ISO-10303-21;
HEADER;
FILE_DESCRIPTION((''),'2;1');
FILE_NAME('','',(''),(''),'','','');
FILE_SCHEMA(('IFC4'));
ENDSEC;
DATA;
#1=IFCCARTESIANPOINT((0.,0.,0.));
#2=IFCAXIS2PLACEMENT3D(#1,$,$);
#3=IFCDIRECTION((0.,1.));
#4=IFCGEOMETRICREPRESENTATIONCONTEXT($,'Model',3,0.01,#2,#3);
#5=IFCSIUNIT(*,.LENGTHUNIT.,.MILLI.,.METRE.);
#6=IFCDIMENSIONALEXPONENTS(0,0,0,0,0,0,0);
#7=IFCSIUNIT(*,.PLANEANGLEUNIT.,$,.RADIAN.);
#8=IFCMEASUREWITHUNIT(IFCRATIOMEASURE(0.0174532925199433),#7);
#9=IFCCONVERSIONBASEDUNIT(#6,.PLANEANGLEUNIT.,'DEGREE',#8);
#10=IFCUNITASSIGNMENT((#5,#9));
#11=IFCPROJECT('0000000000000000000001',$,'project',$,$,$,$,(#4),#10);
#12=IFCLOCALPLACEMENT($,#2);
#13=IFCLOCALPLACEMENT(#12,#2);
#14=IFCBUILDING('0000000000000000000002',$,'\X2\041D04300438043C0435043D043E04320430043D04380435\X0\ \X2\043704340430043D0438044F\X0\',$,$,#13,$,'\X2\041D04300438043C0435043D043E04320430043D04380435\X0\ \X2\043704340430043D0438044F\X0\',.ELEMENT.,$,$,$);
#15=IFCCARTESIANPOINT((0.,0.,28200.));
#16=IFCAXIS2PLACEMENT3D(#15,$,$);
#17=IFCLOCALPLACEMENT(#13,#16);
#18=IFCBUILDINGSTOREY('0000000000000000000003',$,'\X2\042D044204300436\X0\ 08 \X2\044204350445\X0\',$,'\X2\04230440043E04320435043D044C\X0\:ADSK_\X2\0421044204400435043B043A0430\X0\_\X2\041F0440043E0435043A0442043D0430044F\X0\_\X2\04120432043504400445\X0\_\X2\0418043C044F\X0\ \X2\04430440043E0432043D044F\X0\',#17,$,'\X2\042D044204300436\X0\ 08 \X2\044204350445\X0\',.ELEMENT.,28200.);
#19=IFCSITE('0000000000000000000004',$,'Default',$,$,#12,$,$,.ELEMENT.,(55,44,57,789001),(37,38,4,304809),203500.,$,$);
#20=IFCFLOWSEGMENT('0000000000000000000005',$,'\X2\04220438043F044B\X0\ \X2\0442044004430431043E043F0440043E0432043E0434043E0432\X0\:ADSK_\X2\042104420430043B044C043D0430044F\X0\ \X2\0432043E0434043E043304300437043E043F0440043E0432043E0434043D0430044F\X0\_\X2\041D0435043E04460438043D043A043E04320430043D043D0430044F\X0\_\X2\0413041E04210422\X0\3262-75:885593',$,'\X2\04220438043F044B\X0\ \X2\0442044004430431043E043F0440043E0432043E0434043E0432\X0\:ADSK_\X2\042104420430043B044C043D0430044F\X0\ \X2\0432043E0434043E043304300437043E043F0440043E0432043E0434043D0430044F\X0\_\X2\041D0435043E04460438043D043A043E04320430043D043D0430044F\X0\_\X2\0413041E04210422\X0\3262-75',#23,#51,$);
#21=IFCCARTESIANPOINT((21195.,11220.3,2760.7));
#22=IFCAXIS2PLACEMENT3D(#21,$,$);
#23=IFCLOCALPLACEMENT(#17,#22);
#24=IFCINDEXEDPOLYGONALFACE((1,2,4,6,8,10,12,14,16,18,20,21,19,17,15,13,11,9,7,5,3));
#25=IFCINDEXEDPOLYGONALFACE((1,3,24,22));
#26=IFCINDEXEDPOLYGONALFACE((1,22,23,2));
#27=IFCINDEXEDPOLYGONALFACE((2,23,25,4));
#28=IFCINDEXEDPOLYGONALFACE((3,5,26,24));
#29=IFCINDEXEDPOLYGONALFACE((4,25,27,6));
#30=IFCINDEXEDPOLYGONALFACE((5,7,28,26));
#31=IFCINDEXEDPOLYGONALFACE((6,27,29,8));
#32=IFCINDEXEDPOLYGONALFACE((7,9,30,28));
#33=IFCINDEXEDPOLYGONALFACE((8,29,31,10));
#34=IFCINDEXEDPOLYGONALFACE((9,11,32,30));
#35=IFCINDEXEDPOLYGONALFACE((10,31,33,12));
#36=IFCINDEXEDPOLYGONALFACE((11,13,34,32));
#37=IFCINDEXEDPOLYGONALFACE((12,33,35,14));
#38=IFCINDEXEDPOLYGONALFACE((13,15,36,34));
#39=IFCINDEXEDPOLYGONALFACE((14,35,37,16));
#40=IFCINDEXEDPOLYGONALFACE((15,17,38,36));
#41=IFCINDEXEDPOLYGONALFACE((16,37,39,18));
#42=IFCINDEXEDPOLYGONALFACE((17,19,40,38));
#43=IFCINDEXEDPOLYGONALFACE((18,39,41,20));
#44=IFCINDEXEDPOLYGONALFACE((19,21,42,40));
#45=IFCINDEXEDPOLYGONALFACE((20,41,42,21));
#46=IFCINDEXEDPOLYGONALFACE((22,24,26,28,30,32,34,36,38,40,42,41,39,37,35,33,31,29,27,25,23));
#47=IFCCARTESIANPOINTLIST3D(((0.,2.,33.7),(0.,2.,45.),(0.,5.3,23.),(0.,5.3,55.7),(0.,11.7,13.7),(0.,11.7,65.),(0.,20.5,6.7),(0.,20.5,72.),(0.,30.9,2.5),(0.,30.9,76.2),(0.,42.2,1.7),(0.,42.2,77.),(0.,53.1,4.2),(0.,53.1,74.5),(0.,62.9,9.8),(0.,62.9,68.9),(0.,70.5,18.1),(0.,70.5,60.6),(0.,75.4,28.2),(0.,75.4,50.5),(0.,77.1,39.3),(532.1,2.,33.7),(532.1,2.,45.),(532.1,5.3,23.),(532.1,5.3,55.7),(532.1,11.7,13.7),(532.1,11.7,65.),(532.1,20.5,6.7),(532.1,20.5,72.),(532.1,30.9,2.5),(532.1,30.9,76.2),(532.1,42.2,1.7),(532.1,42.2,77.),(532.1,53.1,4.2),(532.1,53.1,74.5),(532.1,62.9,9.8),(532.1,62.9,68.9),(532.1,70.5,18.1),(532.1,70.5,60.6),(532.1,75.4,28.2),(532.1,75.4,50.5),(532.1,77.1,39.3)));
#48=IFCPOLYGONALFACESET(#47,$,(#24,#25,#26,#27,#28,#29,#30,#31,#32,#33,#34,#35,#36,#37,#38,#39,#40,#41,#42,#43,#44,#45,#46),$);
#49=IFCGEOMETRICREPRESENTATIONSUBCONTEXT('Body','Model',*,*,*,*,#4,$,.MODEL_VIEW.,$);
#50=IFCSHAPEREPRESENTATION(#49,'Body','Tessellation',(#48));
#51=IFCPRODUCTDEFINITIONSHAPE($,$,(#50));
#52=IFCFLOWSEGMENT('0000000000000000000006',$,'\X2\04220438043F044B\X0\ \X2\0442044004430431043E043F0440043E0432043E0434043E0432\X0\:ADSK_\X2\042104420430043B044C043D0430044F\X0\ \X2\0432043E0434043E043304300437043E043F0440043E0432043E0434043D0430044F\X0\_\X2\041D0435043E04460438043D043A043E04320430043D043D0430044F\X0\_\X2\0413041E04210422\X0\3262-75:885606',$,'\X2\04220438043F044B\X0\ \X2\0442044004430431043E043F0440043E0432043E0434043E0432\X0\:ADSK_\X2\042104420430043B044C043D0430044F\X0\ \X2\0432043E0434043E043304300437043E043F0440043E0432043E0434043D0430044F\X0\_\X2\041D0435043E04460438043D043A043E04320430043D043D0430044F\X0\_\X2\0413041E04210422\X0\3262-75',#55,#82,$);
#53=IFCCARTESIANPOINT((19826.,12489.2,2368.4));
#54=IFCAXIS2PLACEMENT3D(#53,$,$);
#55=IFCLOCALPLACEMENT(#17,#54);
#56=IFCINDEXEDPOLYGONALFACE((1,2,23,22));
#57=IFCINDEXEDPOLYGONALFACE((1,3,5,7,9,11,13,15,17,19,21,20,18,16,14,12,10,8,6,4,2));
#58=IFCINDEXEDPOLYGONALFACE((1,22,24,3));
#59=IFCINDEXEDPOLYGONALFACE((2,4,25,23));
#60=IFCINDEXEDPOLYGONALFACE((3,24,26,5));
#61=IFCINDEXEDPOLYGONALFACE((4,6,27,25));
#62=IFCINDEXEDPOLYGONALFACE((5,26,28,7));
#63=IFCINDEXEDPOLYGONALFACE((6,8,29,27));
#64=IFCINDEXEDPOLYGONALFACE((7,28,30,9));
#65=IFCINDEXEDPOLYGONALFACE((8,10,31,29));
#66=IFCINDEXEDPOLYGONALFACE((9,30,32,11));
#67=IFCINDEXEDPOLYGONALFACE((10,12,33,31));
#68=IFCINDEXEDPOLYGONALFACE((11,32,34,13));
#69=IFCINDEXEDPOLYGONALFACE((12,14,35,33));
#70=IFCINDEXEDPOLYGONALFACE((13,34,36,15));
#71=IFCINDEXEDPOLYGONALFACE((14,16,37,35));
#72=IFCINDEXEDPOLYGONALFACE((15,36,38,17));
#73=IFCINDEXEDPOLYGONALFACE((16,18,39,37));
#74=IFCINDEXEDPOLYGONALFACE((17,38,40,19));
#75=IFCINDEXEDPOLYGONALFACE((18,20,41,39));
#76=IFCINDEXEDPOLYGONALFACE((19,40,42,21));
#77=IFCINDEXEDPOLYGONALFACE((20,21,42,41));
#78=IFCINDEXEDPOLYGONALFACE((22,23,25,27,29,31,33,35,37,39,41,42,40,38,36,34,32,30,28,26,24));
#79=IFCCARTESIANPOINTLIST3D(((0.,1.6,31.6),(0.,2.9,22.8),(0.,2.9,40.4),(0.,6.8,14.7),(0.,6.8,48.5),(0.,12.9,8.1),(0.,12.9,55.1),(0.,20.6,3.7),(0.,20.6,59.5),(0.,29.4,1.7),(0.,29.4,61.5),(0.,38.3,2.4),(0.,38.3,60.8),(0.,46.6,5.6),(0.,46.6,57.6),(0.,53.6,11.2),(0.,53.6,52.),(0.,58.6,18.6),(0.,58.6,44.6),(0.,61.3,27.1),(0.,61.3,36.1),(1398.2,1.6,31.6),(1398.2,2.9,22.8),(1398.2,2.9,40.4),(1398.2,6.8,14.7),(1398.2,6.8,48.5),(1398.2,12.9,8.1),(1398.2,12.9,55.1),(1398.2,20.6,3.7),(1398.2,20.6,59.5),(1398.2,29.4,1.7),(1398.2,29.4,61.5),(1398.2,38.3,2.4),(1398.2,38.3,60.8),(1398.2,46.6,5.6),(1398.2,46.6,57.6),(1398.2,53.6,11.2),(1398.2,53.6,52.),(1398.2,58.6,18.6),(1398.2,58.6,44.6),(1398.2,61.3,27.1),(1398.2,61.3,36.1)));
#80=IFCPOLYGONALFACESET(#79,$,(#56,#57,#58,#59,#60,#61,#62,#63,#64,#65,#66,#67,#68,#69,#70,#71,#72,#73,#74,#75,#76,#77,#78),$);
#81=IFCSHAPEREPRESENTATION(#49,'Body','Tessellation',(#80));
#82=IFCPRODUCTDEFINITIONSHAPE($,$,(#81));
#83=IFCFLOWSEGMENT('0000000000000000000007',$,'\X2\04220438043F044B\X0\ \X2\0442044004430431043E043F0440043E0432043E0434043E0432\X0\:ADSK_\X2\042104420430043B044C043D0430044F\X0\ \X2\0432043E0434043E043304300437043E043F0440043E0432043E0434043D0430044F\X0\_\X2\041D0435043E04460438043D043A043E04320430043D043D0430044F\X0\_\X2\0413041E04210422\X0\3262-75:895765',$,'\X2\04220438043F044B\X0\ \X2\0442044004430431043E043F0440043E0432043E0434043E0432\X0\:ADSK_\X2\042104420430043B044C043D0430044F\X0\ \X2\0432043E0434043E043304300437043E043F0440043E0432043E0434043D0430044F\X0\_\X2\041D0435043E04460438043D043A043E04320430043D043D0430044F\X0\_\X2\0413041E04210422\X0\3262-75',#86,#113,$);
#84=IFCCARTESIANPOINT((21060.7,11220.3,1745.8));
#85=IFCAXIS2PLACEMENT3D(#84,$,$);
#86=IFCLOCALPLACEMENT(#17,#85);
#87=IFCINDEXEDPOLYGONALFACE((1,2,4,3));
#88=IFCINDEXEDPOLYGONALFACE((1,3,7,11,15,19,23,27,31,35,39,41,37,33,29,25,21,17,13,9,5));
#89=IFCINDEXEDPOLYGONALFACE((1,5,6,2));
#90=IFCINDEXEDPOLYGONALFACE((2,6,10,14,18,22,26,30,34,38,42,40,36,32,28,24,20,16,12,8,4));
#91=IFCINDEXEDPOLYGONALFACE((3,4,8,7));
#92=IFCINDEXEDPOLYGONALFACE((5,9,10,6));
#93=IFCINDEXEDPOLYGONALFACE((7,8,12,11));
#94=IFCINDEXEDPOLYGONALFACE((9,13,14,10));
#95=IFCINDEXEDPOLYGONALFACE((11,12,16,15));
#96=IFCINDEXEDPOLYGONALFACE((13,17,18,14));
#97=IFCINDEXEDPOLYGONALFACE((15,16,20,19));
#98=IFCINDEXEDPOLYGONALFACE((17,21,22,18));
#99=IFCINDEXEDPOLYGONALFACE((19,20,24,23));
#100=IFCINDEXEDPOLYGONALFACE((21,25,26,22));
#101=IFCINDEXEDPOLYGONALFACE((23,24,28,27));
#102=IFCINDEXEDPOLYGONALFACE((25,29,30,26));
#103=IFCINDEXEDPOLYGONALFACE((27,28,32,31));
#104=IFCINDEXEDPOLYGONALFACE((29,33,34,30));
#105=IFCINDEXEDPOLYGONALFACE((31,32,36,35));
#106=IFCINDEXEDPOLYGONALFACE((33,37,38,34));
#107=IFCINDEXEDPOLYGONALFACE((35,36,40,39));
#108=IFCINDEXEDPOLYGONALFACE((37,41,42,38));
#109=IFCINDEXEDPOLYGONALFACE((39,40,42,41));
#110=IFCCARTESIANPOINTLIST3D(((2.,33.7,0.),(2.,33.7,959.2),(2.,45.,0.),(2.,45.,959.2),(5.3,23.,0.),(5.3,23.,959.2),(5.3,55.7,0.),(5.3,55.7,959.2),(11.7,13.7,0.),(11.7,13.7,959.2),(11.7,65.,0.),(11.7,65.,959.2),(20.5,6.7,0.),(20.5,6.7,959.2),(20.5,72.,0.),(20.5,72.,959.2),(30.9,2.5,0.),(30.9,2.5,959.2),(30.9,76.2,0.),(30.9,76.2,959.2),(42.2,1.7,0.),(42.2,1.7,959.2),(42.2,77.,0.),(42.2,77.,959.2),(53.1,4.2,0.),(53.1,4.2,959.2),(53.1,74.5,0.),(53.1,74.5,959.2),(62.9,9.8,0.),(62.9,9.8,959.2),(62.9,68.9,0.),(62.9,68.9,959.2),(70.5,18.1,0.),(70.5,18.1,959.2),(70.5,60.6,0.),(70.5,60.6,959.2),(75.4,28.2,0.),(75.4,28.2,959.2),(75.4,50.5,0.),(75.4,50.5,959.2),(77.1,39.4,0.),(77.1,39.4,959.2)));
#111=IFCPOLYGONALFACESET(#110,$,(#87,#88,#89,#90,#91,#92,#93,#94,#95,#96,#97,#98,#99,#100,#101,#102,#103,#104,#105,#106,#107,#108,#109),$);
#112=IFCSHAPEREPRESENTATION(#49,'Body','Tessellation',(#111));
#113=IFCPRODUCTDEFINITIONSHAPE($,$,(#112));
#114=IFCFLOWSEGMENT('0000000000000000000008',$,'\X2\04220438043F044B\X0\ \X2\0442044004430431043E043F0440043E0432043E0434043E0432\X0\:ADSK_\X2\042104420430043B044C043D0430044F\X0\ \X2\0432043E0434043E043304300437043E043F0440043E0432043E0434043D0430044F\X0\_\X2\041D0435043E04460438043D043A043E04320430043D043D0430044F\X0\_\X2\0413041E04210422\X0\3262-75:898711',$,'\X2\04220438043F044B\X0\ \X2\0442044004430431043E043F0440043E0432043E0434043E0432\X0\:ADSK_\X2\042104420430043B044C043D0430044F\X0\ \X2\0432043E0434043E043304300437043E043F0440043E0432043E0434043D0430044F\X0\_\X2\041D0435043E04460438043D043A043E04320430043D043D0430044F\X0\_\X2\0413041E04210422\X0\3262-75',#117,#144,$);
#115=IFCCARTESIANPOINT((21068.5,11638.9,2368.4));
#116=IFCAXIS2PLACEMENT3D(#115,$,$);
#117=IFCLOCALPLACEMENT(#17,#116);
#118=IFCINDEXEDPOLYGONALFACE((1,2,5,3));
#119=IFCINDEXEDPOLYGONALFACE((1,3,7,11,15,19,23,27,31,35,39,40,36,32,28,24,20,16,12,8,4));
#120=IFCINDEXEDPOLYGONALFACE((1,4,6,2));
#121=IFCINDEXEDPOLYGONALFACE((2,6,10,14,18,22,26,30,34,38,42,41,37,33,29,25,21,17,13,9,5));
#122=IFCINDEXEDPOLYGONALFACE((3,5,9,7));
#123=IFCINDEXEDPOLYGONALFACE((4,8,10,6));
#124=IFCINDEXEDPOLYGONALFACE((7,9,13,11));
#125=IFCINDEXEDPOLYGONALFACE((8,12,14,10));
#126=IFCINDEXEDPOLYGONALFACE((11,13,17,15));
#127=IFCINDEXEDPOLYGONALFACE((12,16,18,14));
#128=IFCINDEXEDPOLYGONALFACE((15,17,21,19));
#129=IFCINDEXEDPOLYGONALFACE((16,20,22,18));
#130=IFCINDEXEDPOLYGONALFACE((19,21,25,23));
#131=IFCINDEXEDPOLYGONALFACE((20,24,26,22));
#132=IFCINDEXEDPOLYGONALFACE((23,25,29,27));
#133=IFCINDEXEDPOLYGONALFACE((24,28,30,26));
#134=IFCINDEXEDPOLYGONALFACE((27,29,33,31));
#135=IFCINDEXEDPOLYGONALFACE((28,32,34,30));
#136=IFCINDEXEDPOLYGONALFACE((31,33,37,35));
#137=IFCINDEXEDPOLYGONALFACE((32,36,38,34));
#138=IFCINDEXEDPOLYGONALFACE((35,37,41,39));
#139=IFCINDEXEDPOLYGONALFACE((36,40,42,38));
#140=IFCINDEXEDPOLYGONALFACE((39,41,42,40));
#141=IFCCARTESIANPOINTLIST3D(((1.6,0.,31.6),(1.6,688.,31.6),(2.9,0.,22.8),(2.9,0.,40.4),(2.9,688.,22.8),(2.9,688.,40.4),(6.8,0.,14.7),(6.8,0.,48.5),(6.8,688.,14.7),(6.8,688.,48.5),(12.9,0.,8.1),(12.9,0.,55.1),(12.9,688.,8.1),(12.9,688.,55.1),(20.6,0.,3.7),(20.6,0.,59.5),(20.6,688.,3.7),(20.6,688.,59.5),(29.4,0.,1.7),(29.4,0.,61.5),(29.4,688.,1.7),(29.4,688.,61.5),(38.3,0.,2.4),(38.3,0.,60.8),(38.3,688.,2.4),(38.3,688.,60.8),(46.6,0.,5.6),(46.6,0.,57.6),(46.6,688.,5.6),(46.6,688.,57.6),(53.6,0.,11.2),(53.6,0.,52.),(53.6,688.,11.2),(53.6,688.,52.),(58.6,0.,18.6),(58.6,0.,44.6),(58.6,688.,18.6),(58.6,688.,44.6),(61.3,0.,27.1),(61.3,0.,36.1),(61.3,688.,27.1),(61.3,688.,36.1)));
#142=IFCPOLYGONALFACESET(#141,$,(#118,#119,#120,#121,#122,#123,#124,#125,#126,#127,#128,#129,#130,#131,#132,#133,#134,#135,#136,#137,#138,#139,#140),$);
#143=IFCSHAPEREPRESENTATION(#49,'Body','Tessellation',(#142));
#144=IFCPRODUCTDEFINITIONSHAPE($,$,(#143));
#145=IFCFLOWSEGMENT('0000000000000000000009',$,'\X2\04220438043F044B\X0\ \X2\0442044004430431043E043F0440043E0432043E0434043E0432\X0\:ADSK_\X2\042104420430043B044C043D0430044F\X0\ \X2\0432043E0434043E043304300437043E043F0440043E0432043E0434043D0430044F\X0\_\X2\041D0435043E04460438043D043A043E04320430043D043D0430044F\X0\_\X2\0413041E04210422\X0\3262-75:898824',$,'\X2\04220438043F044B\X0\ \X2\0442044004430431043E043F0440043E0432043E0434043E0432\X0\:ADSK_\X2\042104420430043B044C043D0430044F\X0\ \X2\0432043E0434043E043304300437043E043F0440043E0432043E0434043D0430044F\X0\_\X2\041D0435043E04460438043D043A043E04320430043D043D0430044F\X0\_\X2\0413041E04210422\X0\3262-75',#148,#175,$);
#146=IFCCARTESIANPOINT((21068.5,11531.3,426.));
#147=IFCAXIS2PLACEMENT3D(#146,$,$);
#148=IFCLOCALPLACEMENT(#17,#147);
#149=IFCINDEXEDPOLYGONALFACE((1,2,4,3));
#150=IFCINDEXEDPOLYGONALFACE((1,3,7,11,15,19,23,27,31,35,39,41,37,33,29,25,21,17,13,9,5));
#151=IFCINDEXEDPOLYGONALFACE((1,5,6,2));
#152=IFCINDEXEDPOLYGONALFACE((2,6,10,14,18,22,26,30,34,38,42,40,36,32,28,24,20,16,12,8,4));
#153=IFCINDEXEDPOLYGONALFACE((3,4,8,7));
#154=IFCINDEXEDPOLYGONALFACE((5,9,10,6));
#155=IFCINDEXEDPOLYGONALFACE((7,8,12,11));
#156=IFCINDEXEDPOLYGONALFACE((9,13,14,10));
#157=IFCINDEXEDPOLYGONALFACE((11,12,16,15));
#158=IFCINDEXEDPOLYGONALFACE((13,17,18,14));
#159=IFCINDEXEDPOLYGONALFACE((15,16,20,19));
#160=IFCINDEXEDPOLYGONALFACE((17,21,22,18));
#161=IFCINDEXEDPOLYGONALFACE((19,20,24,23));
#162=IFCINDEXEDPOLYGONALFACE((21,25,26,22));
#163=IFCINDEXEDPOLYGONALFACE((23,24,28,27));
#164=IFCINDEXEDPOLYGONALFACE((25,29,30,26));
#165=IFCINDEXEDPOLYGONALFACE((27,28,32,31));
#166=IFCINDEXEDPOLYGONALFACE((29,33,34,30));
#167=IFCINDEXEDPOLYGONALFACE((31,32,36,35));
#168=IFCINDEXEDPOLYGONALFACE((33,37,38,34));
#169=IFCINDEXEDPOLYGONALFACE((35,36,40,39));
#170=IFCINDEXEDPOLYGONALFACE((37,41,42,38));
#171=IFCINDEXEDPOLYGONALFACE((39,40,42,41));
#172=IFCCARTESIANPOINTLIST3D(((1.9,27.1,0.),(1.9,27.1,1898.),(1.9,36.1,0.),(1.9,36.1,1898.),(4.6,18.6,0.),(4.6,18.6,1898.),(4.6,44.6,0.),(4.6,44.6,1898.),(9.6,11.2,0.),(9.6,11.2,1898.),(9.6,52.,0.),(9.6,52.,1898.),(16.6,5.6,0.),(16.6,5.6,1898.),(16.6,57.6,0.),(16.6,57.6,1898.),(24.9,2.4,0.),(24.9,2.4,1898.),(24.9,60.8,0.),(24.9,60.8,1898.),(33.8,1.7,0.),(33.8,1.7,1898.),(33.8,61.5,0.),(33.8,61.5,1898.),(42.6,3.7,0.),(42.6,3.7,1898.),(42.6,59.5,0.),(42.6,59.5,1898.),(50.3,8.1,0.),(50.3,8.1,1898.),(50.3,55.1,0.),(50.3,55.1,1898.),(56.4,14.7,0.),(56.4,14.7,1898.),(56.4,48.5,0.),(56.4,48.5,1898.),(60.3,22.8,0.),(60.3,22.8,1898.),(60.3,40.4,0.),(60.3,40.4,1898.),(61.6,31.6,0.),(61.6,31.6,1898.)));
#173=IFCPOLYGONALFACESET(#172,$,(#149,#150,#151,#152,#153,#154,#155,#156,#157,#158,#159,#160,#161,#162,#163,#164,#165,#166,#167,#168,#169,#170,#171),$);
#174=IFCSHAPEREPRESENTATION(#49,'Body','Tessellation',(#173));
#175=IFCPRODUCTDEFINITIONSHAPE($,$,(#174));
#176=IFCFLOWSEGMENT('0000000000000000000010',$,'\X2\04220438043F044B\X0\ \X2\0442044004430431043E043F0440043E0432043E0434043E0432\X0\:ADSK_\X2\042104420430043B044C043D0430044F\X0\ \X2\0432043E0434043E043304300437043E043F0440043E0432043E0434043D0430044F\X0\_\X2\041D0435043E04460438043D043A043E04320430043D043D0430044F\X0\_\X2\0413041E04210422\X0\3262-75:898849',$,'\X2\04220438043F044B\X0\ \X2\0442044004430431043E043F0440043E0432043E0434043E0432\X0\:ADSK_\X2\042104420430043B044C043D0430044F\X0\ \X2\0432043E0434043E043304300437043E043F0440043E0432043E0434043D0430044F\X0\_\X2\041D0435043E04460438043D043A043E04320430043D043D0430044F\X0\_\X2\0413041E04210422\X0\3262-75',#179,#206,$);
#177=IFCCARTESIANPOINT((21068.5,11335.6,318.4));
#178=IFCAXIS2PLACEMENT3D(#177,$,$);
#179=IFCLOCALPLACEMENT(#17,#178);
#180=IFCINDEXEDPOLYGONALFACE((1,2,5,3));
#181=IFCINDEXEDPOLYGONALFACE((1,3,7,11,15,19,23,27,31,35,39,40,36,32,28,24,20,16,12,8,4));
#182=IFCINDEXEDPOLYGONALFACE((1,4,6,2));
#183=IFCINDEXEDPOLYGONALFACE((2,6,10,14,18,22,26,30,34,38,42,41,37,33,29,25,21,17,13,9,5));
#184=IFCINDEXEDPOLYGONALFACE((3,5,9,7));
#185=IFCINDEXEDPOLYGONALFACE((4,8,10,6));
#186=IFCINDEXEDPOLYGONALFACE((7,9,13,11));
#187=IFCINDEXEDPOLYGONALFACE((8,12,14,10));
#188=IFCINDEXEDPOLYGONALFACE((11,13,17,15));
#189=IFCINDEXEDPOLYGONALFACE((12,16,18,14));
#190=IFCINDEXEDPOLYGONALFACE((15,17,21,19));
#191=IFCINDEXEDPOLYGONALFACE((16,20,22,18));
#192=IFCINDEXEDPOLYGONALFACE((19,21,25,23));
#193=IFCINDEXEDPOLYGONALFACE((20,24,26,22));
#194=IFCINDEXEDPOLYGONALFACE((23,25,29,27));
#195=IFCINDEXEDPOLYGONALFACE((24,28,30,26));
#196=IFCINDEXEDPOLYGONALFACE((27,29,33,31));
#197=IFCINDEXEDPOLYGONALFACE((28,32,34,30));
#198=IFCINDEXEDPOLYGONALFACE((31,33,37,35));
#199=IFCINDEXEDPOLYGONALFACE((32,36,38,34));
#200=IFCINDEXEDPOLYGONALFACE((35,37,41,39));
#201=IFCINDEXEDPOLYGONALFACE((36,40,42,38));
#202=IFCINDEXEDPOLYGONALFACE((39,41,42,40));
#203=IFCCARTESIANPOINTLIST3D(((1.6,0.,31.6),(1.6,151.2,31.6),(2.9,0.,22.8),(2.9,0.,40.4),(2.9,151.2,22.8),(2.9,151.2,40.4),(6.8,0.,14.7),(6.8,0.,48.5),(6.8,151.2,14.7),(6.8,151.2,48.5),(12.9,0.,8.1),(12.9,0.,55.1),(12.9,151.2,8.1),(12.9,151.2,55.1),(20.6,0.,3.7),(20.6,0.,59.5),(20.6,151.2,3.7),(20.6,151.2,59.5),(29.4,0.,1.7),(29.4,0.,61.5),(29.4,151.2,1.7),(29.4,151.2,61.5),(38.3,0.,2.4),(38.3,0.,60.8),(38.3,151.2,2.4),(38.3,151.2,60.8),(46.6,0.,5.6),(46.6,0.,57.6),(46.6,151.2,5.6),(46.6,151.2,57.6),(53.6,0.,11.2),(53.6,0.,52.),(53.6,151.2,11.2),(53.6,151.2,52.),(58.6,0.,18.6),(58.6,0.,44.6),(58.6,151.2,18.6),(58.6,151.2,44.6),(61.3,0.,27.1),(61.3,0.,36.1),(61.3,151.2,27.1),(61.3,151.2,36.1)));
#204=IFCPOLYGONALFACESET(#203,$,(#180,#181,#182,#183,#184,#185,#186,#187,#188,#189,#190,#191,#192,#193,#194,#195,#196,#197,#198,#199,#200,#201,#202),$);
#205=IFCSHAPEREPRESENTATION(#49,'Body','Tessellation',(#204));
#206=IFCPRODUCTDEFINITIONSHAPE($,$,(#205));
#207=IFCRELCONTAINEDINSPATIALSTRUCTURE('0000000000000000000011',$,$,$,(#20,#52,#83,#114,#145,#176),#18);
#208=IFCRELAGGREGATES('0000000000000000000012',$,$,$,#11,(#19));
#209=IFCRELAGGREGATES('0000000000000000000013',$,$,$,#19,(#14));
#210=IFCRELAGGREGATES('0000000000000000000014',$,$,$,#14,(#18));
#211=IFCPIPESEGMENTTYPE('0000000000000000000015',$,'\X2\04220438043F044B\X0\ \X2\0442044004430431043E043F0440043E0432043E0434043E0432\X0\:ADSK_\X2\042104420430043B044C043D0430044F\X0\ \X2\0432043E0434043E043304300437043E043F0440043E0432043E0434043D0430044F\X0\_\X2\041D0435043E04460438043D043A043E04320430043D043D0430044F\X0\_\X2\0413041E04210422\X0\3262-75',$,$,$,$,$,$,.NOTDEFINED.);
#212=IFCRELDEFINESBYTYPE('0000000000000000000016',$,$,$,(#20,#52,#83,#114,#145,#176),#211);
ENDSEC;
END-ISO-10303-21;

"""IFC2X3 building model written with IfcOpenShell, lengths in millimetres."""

from ifc_helpers import new_model, entity, si_unit, converted_unit, direction, frame, origin, origin_2d_with_axis, place, context, subcontext, project, spatial, circle, extrude, type_object, element, save


model = new_model("IFC2X3")

# Units and contexts
model_context = context("Model", 3, precision=0.01, world=origin(), true_north=direction((0.0, 1.0)))
body_context = subcontext(model_context, "Body", "Model", "MODEL_VIEW")
ifc_project = project(units=[si_unit("LENGTHUNIT", "METRE", prefix="MILLI"), converted_unit("PLANEANGLEUNIT", "DEGREE", entity("IfcRatioMeasure", 0.0174532925199433), si_unit("PLANEANGLEUNIT", "RADIAN"), dimensions=[0, 0, 0, 0, 0, 0, 0])], contexts=[model_context])

# Site, building, storey
site_placement = place(None, origin())
site = spatial("IfcSite", under=ifc_project, at=site_placement, Name="Default", CompositionType="ELEMENT", RefLatitude=(55, 44, 57, 789001), RefLongitude=(37, 38, 4, 304809), RefElevation=203500.0)
building_placement = place(site_placement, origin())
building = spatial("IfcBuilding", under=site, at=building_placement, Name="Наименование здания", LongName="Наименование здания", CompositionType="ELEMENT")
storey_placement = place(building_placement, frame((0.0, 0.0, 28200.0)))
storey = spatial("IfcBuildingStorey", under=building, at=storey_placement, Name="Этаж 08 тех", ObjectType="Уровень:ADSK_Стрелка_Проектная_Вверх_Имя уровня", LongName="Этаж 08 тех", CompositionType="ELEMENT", Elevation=28200.0)

# Flow segments
pipe_segment_type = type_object("IfcPipeSegmentType", Name="Типы трубопроводов:ADSK_Стальная водогазопроводная_Неоцинкованная_ГОСТ3262-75", PredefinedType="NOTDEFINED")
flow_segment_1_placement = place(storey_placement, frame((21195.0, 11220.3, 2760.7)))
element("IfcFlowSegment", 1, at=flow_segment_1_placement, inside=storey, type_object=pipe_segment_type, Name="Типы трубопроводов:ADSK_Стальная водогазопроводная_Неоцинкованная_ГОСТ3262-75:885593", ObjectType="Типы трубопроводов:ADSK_Стальная водогазопроводная_Неоцинкованная_ГОСТ3262-75", context=body_context, shape_type="SweptSolid", body=[
    extrude(circle(Radius=37.8, at=origin_2d_with_axis()), frame((0.0, 39.4, 39.4), z_axis=(1.0, 0.0, 0.0), x_axis=(0.0, 1.0, 0.0)), (0.0, 0.0, 1.0), 532.1),
])
flow_segment_2_placement = place(storey_placement, frame((19826.0, 12489.2, 2368.4)))
element("IfcFlowSegment", 2, at=flow_segment_2_placement, inside=storey, type_object=pipe_segment_type, Name="Типы трубопроводов:ADSK_Стальная водогазопроводная_Неоцинкованная_ГОСТ3262-75:885606", ObjectType="Типы трубопроводов:ADSK_Стальная водогазопроводная_Неоцинкованная_ГОСТ3262-75", context=body_context, shape_type="SweptSolid", body=[
    extrude(circle(Radius=30.0, at=origin_2d_with_axis()), frame((0.0, 31.6, 31.6), z_axis=(1.0, 0.0, 0.0), x_axis=(0.0, -1.0, 0.0)), (0.0, 0.0, 1.0), 1398.2),
])
flow_segment_3_placement = place(storey_placement, frame((21060.7, 11220.3, 1745.8)))
element("IfcFlowSegment", 3, at=flow_segment_3_placement, inside=storey, type_object=pipe_segment_type, Name="Типы трубопроводов:ADSK_Стальная водогазопроводная_Неоцинкованная_ГОСТ3262-75:895765", ObjectType="Типы трубопроводов:ADSK_Стальная водогазопроводная_Неоцинкованная_ГОСТ3262-75", context=body_context, shape_type="SweptSolid", body=[
    extrude(circle(Radius=37.8, at=origin_2d_with_axis()), frame((39.4, 39.4, 0.0)), (0.0, 0.0, 1.0), 959.2),
])
flow_segment_4_placement = place(storey_placement, frame((21068.5, 11638.9, 2368.4)))
element("IfcFlowSegment", 4, at=flow_segment_4_placement, inside=storey, type_object=pipe_segment_type, Name="Типы трубопроводов:ADSK_Стальная водогазопроводная_Неоцинкованная_ГОСТ3262-75:898711", ObjectType="Типы трубопроводов:ADSK_Стальная водогазопроводная_Неоцинкованная_ГОСТ3262-75", context=body_context, shape_type="SweptSolid", body=[
    extrude(circle(Radius=30.0, at=origin_2d_with_axis()), frame((31.6, 0.0, 31.6), z_axis=(0.0, 1.0, 0.0), x_axis=(-1.0, 0.0, 0.0)), (0.0, 0.0, 1.0), 688.0),
])
flow_segment_5_placement = place(storey_placement, frame((21068.5, 11531.3, 426.0)))
element("IfcFlowSegment", 5, at=flow_segment_5_placement, inside=storey, type_object=pipe_segment_type, Name="Типы трубопроводов:ADSK_Стальная водогазопроводная_Неоцинкованная_ГОСТ3262-75:898824", ObjectType="Типы трубопроводов:ADSK_Стальная водогазопроводная_Неоцинкованная_ГОСТ3262-75", context=body_context, shape_type="SweptSolid", body=[
    extrude(circle(Radius=30.0, at=origin_2d_with_axis()), frame((31.6, 31.6, 0.0)), (0.0, 0.0, 1.0), 1898.0),
])
flow_segment_6_placement = place(storey_placement, frame((21068.5, 11335.6, 318.4)))
element("IfcFlowSegment", 6, at=flow_segment_6_placement, inside=storey, type_object=pipe_segment_type, Name="Типы трубопроводов:ADSK_Стальная водогазопроводная_Неоцинкованная_ГОСТ3262-75:898849", ObjectType="Типы трубопроводов:ADSK_Стальная водогазопроводная_Неоцинкованная_ГОСТ3262-75", context=body_context, shape_type="SweptSolid", body=[
    extrude(circle(Radius=30.0, at=origin_2d_with_axis()), frame((31.6, 0.0, 31.6), z_axis=(0.0, 1.0, 0.0), x_axis=(-1.0, 0.0, 0.0)), (0.0, 0.0, 1.0), 151.2),
])

save(model, "model.ifc")
